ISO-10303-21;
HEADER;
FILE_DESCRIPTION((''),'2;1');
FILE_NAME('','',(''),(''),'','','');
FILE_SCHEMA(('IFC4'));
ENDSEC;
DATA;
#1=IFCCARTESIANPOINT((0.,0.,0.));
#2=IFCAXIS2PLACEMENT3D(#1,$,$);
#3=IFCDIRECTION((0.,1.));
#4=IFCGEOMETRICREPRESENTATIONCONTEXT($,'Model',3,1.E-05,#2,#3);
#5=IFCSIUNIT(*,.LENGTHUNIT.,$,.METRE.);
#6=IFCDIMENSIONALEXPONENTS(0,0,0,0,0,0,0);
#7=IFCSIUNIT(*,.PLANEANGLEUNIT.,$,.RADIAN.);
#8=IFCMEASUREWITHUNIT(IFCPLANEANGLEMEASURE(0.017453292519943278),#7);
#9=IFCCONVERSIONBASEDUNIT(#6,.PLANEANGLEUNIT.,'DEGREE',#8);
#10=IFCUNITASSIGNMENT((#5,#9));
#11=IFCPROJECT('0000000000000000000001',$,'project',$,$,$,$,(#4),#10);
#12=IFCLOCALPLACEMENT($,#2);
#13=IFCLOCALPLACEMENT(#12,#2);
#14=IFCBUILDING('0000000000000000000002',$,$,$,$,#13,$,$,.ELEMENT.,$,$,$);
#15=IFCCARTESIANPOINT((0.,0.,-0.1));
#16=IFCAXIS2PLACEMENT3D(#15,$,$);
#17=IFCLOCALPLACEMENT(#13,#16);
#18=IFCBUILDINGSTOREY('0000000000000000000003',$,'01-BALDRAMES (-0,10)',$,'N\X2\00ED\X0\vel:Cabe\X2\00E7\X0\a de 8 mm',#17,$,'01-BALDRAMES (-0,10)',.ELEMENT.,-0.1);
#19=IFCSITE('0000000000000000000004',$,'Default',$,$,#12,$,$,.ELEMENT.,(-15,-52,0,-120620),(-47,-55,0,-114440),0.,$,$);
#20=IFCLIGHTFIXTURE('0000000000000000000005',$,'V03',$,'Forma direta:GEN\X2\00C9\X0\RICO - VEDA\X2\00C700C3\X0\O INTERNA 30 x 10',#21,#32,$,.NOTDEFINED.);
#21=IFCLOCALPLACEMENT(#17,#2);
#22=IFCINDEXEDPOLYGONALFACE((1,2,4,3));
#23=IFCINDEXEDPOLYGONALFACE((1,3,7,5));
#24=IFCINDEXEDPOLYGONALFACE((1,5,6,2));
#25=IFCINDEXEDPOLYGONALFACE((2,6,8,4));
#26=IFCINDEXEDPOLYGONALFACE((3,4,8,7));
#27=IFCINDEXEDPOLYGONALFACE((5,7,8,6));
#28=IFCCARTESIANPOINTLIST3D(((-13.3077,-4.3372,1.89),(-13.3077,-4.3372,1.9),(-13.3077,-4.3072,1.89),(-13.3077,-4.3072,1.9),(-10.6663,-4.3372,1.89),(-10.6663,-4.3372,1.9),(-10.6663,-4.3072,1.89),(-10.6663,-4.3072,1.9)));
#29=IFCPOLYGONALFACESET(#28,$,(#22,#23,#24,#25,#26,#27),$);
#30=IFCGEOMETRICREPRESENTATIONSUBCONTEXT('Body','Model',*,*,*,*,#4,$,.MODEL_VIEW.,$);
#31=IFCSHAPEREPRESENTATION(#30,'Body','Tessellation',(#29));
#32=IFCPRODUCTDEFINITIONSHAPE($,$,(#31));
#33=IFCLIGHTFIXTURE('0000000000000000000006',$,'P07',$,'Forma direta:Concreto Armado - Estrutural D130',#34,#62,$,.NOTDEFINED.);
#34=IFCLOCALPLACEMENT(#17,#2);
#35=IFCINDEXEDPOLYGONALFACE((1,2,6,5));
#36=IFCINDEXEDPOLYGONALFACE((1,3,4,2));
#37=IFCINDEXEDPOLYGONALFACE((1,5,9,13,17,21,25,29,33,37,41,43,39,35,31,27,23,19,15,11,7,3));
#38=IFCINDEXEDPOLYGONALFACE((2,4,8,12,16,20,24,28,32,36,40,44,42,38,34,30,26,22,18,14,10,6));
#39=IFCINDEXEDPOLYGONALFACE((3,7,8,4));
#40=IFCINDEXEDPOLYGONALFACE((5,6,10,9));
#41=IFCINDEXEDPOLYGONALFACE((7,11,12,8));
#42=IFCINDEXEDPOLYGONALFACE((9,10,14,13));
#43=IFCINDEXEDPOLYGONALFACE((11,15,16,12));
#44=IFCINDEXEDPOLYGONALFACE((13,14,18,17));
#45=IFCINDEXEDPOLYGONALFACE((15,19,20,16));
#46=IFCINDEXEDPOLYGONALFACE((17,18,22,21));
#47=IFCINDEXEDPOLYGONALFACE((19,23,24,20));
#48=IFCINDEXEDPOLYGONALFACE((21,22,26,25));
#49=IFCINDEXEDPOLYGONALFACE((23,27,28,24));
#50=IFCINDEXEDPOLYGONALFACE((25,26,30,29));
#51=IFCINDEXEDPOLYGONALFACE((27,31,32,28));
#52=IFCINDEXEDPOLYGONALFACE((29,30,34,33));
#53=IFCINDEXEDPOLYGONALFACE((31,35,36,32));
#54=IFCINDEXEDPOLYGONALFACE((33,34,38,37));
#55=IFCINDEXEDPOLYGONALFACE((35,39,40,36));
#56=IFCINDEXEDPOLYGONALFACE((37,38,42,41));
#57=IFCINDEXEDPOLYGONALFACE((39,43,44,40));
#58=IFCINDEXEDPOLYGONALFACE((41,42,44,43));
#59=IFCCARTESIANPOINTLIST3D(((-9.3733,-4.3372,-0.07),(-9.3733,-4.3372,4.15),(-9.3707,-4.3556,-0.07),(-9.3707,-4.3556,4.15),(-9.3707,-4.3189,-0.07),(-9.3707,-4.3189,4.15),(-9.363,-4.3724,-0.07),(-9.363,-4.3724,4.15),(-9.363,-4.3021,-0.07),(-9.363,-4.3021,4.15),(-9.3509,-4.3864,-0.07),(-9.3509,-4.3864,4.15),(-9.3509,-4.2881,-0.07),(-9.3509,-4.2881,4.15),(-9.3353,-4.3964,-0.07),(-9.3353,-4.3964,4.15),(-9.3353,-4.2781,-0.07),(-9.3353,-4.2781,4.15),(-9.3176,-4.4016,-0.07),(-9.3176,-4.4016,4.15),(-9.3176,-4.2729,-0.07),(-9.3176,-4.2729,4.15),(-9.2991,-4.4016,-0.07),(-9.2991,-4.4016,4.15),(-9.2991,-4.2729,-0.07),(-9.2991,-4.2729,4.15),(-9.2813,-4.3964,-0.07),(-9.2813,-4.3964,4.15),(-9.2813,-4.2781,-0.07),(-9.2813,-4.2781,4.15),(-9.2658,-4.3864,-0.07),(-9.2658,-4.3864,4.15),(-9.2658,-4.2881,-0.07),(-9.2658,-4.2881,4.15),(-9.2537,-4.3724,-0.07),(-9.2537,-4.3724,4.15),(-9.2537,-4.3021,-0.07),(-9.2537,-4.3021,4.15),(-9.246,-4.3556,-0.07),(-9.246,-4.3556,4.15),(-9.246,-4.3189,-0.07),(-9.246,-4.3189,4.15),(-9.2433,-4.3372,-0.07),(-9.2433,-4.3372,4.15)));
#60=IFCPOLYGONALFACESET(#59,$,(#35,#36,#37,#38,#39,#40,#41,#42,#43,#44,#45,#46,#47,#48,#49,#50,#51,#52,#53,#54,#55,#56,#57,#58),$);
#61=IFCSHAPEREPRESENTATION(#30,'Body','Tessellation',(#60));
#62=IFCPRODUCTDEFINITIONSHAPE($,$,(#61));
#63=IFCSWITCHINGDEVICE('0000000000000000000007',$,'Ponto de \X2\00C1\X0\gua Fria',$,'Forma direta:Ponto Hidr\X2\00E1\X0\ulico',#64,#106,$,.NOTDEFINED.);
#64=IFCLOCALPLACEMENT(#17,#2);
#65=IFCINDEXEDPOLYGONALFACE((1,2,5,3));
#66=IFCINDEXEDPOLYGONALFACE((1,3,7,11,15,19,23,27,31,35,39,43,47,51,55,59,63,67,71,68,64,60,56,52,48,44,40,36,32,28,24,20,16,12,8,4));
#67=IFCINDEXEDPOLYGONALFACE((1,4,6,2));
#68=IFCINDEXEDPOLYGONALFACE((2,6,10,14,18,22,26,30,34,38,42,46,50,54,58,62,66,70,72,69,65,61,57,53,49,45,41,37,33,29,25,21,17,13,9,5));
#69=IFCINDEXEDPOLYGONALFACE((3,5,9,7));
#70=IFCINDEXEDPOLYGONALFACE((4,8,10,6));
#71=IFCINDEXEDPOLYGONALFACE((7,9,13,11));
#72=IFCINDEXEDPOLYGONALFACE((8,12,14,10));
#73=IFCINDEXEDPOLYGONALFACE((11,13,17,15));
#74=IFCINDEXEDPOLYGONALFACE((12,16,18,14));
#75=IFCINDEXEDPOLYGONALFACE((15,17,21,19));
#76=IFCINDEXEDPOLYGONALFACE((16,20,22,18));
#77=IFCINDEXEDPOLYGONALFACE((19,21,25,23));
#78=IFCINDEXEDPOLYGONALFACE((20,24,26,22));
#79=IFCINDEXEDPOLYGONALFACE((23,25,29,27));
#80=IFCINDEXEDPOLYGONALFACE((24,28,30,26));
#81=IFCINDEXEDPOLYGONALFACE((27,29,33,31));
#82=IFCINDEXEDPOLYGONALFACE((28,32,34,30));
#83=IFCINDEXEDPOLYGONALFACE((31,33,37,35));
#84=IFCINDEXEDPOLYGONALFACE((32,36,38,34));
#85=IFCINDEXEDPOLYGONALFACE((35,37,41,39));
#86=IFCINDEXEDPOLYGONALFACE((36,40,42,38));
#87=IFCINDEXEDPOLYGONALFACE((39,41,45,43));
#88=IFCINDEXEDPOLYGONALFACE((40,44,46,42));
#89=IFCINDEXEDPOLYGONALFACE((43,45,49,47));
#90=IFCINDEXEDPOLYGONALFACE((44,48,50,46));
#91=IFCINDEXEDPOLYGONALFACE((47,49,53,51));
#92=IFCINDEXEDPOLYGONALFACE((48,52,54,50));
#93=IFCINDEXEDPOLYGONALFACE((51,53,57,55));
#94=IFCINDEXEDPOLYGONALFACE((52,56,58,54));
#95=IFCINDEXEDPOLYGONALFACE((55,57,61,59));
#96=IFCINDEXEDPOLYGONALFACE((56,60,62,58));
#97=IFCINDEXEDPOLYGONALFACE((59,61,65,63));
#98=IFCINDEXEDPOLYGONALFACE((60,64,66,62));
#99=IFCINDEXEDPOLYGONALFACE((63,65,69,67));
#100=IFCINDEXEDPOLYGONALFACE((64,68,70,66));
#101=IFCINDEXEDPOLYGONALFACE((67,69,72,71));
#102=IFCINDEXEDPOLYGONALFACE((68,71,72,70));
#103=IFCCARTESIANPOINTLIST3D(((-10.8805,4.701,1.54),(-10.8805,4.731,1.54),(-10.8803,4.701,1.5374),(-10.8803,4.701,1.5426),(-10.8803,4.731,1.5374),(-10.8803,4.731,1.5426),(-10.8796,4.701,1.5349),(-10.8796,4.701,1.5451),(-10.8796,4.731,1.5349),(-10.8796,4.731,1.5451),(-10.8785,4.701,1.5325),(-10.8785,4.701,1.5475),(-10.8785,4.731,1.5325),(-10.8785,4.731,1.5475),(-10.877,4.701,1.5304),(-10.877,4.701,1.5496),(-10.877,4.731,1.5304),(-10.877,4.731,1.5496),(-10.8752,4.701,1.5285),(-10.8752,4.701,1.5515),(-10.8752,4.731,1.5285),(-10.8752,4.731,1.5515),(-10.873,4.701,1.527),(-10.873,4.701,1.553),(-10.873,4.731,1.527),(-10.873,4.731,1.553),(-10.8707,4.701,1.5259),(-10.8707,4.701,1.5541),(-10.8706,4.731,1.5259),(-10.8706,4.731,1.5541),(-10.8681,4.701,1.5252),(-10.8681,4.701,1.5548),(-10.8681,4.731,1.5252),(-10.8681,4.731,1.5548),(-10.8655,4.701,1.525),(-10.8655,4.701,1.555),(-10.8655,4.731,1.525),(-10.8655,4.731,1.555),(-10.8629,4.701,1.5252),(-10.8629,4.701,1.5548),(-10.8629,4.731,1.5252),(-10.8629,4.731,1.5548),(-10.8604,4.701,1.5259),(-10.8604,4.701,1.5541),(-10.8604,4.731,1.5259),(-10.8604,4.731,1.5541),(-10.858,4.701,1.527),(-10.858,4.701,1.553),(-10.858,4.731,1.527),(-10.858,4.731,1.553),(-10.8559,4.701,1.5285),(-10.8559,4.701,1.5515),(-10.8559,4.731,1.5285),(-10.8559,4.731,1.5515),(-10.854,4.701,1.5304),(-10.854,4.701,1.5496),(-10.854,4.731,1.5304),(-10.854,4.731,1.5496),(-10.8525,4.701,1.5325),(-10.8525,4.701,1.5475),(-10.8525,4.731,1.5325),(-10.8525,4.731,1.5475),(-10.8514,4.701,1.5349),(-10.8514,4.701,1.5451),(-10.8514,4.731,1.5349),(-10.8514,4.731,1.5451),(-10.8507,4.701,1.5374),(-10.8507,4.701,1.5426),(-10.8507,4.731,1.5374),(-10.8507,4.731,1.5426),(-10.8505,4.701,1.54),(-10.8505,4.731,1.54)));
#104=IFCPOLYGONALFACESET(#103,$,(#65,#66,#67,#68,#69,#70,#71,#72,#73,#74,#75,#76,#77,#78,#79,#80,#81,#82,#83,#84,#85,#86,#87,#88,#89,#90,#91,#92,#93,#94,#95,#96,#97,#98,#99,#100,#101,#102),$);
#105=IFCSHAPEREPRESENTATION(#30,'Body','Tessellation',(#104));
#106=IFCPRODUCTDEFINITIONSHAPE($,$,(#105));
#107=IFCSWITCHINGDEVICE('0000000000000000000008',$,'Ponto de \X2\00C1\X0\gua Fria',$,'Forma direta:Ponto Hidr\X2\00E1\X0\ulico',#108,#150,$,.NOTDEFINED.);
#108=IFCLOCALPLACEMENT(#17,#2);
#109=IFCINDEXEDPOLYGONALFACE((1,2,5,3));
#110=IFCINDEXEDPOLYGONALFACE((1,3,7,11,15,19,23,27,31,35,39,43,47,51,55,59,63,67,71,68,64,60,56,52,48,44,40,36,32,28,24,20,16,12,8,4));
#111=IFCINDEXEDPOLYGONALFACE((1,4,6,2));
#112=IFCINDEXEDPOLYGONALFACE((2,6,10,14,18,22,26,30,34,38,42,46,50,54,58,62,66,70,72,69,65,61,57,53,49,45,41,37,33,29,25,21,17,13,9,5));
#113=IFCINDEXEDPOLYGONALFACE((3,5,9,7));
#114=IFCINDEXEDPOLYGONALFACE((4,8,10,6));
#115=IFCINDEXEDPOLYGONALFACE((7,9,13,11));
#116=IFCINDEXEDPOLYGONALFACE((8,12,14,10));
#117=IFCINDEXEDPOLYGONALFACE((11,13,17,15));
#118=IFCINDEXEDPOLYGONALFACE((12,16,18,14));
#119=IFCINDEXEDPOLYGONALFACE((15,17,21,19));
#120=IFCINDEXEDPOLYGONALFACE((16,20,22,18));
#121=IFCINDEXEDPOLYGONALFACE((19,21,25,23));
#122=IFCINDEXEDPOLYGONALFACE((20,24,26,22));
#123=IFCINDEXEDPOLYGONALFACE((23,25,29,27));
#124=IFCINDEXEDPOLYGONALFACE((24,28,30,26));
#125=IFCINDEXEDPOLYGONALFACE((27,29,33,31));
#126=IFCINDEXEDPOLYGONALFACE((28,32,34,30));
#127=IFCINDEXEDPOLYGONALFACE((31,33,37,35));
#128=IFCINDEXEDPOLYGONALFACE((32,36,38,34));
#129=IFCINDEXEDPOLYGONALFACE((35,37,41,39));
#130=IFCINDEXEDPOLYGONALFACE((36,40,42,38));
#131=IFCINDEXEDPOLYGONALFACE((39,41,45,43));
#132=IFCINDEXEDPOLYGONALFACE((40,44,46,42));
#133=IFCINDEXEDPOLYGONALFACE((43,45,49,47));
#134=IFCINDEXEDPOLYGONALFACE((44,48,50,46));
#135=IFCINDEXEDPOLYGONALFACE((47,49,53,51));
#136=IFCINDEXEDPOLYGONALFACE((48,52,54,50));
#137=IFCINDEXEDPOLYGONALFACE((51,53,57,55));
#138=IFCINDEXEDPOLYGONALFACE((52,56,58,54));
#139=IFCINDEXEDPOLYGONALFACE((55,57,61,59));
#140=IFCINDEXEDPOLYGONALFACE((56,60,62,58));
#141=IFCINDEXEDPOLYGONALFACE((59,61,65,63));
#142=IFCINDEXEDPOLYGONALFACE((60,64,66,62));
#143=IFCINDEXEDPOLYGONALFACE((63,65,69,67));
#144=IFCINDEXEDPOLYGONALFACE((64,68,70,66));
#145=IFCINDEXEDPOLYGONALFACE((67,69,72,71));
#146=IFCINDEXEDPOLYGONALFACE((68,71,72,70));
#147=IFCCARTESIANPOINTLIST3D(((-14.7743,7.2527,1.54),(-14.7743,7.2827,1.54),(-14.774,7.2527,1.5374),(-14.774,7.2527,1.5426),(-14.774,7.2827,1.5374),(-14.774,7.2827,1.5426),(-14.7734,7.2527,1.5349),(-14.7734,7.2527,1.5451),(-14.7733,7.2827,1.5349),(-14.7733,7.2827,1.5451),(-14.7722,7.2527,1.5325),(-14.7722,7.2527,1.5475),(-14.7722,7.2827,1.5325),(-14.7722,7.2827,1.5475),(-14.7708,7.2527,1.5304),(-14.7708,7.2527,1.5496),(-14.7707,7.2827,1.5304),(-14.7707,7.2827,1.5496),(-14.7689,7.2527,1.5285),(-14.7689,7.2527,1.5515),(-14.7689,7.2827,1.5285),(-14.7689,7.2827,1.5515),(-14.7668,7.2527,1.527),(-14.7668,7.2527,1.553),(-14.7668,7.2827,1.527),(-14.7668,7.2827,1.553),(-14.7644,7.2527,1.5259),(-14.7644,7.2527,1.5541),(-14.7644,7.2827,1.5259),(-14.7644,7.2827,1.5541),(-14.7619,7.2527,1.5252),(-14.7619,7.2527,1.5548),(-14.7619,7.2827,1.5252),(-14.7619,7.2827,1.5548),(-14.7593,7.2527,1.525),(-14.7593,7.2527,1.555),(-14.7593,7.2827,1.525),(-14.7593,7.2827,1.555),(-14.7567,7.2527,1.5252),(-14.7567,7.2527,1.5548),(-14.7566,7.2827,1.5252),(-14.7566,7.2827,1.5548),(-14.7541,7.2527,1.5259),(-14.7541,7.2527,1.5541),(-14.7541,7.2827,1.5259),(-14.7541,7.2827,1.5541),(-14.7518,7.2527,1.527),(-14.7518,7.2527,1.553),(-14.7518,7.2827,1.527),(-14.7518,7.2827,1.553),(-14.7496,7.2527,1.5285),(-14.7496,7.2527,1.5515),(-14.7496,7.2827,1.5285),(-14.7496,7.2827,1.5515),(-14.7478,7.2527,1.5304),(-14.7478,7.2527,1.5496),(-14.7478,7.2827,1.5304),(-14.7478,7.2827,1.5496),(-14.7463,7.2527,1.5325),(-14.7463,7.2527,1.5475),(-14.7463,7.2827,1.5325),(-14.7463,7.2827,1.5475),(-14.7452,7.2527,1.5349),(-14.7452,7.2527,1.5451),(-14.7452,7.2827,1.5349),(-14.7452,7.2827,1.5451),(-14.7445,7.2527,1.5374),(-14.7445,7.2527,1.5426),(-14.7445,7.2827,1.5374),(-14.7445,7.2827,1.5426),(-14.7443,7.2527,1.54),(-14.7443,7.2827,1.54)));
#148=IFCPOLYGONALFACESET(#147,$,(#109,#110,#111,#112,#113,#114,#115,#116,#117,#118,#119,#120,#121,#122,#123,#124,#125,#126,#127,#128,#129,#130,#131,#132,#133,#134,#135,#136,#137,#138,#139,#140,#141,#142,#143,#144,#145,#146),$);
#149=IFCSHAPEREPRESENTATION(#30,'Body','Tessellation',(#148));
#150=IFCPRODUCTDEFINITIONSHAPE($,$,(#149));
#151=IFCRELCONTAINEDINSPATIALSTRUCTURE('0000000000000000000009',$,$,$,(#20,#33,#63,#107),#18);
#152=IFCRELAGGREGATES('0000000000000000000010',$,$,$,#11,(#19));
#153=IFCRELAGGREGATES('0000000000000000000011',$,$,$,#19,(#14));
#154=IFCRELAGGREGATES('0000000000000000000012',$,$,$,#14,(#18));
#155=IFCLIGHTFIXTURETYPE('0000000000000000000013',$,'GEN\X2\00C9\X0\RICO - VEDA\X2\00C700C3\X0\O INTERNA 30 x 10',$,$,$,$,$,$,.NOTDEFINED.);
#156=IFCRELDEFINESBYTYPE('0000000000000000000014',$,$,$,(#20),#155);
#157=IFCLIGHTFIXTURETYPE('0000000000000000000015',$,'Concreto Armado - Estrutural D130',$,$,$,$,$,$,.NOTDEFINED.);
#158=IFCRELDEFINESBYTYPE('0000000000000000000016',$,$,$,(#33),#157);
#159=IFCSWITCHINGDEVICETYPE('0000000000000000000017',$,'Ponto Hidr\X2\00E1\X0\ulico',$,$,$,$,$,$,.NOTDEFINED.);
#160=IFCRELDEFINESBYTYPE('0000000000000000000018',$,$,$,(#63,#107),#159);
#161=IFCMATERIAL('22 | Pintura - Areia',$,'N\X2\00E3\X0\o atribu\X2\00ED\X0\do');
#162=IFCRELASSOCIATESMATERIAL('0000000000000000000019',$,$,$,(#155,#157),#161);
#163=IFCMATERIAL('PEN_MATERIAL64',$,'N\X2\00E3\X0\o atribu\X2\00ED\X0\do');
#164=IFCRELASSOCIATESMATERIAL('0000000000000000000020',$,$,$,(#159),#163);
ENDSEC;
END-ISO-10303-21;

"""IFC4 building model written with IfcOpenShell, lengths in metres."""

from ifc_helpers import new_model, entity, si_unit, converted_unit, direction, frame, origin, place, context, subcontext, project, spatial, arc, indexed_curve, outline, extrude, material, type_object, element, save


model = new_model("IFC4")

# Units and contexts
model_context = context("Model", 3, precision=1e-05, world=origin(), true_north=direction((0.0, 1.0)))
body_context = subcontext(model_context, "Body", "Model", "MODEL_VIEW")
ifc_project = project(units=[si_unit("LENGTHUNIT", "METRE"), converted_unit("PLANEANGLEUNIT", "DEGREE", entity("IfcPlaneAngleMeasure", 0.017453292519943278), si_unit("PLANEANGLEUNIT", "RADIAN"), dimensions=[0, 0, 0, 0, 0, 0, 0])], contexts=[model_context])

# Site, building, storey
site_placement = place(None, origin())
site = spatial("IfcSite", under=ifc_project, at=site_placement, Name="Default", CompositionType="ELEMENT", RefLatitude=(-15, -52, 0, -120620), RefLongitude=(-47, -55, 0, -114440), RefElevation=0.0)
building_placement = place(site_placement, origin())
building = spatial("IfcBuilding", under=site, at=building_placement, CompositionType="ELEMENT")
storey_placement = place(building_placement, frame((0.0, 0.0, -0.1)))
storey = spatial("IfcBuildingStorey", under=building, at=storey_placement, Name="01-BALDRAMES (-0,10)", ObjectType="Nível:Cabeça de 8 mm", LongName="01-BALDRAMES (-0,10)", CompositionType="ELEMENT", Elevation=-0.1)

# Shared definitions
ifc_material_1 = material(Name="22 | Pintura - Areia", Category="Não atribuído")

# Light fixtures
light_fixture_type_1 = type_object("IfcLightFixtureType", Name="GENÉRICO - VEDAÇÃO INTERNA 30 x 10", PredefinedType="NOTDEFINED", material=ifc_material_1)
light_fixture_1_placement = place(storey_placement, origin())
element("IfcLightFixture", 1, at=light_fixture_1_placement, inside=storey, type_object=light_fixture_type_1, Name="V03", ObjectType="Forma direta:GENÉRICO - VEDAÇÃO INTERNA 30 x 10", PredefinedType="NOTDEFINED", context=body_context, shape_type="SweptSolid", body=[
    extrude(outline(indexed_curve([(-1.3207, -0.015), (1.3207, -0.015), (1.3207, 0.015), (-1.3207, 0.015), (-1.3207, -0.015)], self_intersect=False)), frame((-11.987, -4.3222, 1.89)), (0.0, 0.0, 1.0), 0.01),
])
light_fixture_type_2 = type_object("IfcLightFixtureType", Name="Concreto Armado - Estrutural D130", PredefinedType="NOTDEFINED", material=ifc_material_1)
light_fixture_2_placement = place(storey_placement, origin())
element("IfcLightFixture", 2, at=light_fixture_2_placement, inside=storey, type_object=light_fixture_type_2, Name="P07", ObjectType="Forma direta:Concreto Armado - Estrutural D130", PredefinedType="NOTDEFINED", context=body_context, shape_type="SweptSolid", body=[
    extrude(outline(indexed_curve([(0.065, 0.0), (0.0, 0.065), (-0.065, 0.0), (0.0, -0.065)], segments=[arc(1, 2, 3), arc(3, 4, 1)], self_intersect=False)), frame((-9.3083, -4.3372, -0.07)), (0.0, 0.0, 1.0), 4.22),
])

# Switching devices
ifc_material_2 = material(Name="PEN_MATERIAL64", Category="Não atribuído")
switching_device_type_1 = type_object("IfcSwitchingDeviceType", Name="Ponto Hidráulico", PredefinedType="NOTDEFINED", material=ifc_material_2)
switching_device_1_placement = place(storey_placement, origin())
element("IfcSwitchingDevice", 3, at=switching_device_1_placement, inside=storey, type_object=switching_device_type_1, Name="Ponto de Água Fria", ObjectType="Forma direta:Ponto Hidráulico", PredefinedType="NOTDEFINED", context=body_context, shape_type="SweptSolid", body=[
    extrude(outline(indexed_curve([(-0.0013, -0.0149), (0.0013, -0.0149), (0.0039, -0.0145), (0.0063, -0.0136), (0.0086, -0.0123), (0.0106, -0.0106), (0.0123, -0.0086), (0.0136, -0.0063), (0.0145, -0.0039), (0.0149, -0.0013), (0.0149, 0.0013), (0.0145, 0.0039), (0.0136, 0.0063), (0.0123, 0.0086), (0.0106, 0.0106), (0.0086, 0.0123), (0.0063, 0.0136), (0.0039, 0.0145), (0.0013, 0.0149), (-0.0013, 0.0149), (-0.0039, 0.0145), (-0.0063, 0.0136), (-0.0086, 0.0123), (-0.0106, 0.0106), (-0.0123, 0.0086), (-0.0136, 0.0063), (-0.0145, 0.0039), (-0.0149, 0.0013), (-0.0149, -0.0013), (-0.0145, -0.0039), (-0.0136, -0.0063), (-0.0123, -0.0086), (-0.0106, -0.0106), (-0.0086, -0.0123), (-0.0063, -0.0136), (-0.0039, -0.0145), (-0.0013, -0.0149)], self_intersect=False)), frame((-10.8655, 4.701, 1.54), z_axis=(0.000299, 1.0, 0.0), x_axis=(-0.996195, 0.000298, -0.087156)), (0.0, 0.0, 1.0), 0.03),
])
switching_device_2_placement = place(storey_placement, origin())
element("IfcSwitchingDevice", 4, at=switching_device_2_placement, inside=storey, type_object=switching_device_type_1, Name="Ponto de Água Fria", ObjectType="Forma direta:Ponto Hidráulico", PredefinedType="NOTDEFINED", context=body_context, shape_type="SweptSolid", body=[
    extrude(outline(indexed_curve([(-0.0013, -0.0149), (0.0013, -0.0149), (0.0039, -0.0145), (0.0063, -0.0136), (0.0086, -0.0123), (0.0106, -0.0106), (0.0123, -0.0086), (0.0136, -0.0063), (0.0145, -0.0039), (0.0149, -0.0013), (0.0149, 0.0013), (0.0145, 0.0039), (0.0136, 0.0063), (0.0123, 0.0086), (0.0106, 0.0106), (0.0086, 0.0123), (0.0063, 0.0136), (0.0039, 0.0145), (0.0013, 0.0149), (-0.0013, 0.0149), (-0.0039, 0.0145), (-0.0063, 0.0136), (-0.0086, 0.0123), (-0.0106, 0.0106), (-0.0123, 0.0086), (-0.0136, 0.0063), (-0.0145, 0.0039), (-0.0149, 0.0013), (-0.0149, -0.0013), (-0.0145, -0.0039), (-0.0136, -0.0063), (-0.0123, -0.0086), (-0.0106, -0.0106), (-0.0086, -0.0123), (-0.0063, -0.0136), (-0.0039, -0.0145), (-0.0013, -0.0149)], self_intersect=False)), frame((-14.7593, 7.2527, 1.54), z_axis=(0.000299, 1.0, 0.0), x_axis=(-0.996195, 0.000298, -0.087156)), (0.0, 0.0, 1.0), 0.03),
])

save(model, "model.ifc")
